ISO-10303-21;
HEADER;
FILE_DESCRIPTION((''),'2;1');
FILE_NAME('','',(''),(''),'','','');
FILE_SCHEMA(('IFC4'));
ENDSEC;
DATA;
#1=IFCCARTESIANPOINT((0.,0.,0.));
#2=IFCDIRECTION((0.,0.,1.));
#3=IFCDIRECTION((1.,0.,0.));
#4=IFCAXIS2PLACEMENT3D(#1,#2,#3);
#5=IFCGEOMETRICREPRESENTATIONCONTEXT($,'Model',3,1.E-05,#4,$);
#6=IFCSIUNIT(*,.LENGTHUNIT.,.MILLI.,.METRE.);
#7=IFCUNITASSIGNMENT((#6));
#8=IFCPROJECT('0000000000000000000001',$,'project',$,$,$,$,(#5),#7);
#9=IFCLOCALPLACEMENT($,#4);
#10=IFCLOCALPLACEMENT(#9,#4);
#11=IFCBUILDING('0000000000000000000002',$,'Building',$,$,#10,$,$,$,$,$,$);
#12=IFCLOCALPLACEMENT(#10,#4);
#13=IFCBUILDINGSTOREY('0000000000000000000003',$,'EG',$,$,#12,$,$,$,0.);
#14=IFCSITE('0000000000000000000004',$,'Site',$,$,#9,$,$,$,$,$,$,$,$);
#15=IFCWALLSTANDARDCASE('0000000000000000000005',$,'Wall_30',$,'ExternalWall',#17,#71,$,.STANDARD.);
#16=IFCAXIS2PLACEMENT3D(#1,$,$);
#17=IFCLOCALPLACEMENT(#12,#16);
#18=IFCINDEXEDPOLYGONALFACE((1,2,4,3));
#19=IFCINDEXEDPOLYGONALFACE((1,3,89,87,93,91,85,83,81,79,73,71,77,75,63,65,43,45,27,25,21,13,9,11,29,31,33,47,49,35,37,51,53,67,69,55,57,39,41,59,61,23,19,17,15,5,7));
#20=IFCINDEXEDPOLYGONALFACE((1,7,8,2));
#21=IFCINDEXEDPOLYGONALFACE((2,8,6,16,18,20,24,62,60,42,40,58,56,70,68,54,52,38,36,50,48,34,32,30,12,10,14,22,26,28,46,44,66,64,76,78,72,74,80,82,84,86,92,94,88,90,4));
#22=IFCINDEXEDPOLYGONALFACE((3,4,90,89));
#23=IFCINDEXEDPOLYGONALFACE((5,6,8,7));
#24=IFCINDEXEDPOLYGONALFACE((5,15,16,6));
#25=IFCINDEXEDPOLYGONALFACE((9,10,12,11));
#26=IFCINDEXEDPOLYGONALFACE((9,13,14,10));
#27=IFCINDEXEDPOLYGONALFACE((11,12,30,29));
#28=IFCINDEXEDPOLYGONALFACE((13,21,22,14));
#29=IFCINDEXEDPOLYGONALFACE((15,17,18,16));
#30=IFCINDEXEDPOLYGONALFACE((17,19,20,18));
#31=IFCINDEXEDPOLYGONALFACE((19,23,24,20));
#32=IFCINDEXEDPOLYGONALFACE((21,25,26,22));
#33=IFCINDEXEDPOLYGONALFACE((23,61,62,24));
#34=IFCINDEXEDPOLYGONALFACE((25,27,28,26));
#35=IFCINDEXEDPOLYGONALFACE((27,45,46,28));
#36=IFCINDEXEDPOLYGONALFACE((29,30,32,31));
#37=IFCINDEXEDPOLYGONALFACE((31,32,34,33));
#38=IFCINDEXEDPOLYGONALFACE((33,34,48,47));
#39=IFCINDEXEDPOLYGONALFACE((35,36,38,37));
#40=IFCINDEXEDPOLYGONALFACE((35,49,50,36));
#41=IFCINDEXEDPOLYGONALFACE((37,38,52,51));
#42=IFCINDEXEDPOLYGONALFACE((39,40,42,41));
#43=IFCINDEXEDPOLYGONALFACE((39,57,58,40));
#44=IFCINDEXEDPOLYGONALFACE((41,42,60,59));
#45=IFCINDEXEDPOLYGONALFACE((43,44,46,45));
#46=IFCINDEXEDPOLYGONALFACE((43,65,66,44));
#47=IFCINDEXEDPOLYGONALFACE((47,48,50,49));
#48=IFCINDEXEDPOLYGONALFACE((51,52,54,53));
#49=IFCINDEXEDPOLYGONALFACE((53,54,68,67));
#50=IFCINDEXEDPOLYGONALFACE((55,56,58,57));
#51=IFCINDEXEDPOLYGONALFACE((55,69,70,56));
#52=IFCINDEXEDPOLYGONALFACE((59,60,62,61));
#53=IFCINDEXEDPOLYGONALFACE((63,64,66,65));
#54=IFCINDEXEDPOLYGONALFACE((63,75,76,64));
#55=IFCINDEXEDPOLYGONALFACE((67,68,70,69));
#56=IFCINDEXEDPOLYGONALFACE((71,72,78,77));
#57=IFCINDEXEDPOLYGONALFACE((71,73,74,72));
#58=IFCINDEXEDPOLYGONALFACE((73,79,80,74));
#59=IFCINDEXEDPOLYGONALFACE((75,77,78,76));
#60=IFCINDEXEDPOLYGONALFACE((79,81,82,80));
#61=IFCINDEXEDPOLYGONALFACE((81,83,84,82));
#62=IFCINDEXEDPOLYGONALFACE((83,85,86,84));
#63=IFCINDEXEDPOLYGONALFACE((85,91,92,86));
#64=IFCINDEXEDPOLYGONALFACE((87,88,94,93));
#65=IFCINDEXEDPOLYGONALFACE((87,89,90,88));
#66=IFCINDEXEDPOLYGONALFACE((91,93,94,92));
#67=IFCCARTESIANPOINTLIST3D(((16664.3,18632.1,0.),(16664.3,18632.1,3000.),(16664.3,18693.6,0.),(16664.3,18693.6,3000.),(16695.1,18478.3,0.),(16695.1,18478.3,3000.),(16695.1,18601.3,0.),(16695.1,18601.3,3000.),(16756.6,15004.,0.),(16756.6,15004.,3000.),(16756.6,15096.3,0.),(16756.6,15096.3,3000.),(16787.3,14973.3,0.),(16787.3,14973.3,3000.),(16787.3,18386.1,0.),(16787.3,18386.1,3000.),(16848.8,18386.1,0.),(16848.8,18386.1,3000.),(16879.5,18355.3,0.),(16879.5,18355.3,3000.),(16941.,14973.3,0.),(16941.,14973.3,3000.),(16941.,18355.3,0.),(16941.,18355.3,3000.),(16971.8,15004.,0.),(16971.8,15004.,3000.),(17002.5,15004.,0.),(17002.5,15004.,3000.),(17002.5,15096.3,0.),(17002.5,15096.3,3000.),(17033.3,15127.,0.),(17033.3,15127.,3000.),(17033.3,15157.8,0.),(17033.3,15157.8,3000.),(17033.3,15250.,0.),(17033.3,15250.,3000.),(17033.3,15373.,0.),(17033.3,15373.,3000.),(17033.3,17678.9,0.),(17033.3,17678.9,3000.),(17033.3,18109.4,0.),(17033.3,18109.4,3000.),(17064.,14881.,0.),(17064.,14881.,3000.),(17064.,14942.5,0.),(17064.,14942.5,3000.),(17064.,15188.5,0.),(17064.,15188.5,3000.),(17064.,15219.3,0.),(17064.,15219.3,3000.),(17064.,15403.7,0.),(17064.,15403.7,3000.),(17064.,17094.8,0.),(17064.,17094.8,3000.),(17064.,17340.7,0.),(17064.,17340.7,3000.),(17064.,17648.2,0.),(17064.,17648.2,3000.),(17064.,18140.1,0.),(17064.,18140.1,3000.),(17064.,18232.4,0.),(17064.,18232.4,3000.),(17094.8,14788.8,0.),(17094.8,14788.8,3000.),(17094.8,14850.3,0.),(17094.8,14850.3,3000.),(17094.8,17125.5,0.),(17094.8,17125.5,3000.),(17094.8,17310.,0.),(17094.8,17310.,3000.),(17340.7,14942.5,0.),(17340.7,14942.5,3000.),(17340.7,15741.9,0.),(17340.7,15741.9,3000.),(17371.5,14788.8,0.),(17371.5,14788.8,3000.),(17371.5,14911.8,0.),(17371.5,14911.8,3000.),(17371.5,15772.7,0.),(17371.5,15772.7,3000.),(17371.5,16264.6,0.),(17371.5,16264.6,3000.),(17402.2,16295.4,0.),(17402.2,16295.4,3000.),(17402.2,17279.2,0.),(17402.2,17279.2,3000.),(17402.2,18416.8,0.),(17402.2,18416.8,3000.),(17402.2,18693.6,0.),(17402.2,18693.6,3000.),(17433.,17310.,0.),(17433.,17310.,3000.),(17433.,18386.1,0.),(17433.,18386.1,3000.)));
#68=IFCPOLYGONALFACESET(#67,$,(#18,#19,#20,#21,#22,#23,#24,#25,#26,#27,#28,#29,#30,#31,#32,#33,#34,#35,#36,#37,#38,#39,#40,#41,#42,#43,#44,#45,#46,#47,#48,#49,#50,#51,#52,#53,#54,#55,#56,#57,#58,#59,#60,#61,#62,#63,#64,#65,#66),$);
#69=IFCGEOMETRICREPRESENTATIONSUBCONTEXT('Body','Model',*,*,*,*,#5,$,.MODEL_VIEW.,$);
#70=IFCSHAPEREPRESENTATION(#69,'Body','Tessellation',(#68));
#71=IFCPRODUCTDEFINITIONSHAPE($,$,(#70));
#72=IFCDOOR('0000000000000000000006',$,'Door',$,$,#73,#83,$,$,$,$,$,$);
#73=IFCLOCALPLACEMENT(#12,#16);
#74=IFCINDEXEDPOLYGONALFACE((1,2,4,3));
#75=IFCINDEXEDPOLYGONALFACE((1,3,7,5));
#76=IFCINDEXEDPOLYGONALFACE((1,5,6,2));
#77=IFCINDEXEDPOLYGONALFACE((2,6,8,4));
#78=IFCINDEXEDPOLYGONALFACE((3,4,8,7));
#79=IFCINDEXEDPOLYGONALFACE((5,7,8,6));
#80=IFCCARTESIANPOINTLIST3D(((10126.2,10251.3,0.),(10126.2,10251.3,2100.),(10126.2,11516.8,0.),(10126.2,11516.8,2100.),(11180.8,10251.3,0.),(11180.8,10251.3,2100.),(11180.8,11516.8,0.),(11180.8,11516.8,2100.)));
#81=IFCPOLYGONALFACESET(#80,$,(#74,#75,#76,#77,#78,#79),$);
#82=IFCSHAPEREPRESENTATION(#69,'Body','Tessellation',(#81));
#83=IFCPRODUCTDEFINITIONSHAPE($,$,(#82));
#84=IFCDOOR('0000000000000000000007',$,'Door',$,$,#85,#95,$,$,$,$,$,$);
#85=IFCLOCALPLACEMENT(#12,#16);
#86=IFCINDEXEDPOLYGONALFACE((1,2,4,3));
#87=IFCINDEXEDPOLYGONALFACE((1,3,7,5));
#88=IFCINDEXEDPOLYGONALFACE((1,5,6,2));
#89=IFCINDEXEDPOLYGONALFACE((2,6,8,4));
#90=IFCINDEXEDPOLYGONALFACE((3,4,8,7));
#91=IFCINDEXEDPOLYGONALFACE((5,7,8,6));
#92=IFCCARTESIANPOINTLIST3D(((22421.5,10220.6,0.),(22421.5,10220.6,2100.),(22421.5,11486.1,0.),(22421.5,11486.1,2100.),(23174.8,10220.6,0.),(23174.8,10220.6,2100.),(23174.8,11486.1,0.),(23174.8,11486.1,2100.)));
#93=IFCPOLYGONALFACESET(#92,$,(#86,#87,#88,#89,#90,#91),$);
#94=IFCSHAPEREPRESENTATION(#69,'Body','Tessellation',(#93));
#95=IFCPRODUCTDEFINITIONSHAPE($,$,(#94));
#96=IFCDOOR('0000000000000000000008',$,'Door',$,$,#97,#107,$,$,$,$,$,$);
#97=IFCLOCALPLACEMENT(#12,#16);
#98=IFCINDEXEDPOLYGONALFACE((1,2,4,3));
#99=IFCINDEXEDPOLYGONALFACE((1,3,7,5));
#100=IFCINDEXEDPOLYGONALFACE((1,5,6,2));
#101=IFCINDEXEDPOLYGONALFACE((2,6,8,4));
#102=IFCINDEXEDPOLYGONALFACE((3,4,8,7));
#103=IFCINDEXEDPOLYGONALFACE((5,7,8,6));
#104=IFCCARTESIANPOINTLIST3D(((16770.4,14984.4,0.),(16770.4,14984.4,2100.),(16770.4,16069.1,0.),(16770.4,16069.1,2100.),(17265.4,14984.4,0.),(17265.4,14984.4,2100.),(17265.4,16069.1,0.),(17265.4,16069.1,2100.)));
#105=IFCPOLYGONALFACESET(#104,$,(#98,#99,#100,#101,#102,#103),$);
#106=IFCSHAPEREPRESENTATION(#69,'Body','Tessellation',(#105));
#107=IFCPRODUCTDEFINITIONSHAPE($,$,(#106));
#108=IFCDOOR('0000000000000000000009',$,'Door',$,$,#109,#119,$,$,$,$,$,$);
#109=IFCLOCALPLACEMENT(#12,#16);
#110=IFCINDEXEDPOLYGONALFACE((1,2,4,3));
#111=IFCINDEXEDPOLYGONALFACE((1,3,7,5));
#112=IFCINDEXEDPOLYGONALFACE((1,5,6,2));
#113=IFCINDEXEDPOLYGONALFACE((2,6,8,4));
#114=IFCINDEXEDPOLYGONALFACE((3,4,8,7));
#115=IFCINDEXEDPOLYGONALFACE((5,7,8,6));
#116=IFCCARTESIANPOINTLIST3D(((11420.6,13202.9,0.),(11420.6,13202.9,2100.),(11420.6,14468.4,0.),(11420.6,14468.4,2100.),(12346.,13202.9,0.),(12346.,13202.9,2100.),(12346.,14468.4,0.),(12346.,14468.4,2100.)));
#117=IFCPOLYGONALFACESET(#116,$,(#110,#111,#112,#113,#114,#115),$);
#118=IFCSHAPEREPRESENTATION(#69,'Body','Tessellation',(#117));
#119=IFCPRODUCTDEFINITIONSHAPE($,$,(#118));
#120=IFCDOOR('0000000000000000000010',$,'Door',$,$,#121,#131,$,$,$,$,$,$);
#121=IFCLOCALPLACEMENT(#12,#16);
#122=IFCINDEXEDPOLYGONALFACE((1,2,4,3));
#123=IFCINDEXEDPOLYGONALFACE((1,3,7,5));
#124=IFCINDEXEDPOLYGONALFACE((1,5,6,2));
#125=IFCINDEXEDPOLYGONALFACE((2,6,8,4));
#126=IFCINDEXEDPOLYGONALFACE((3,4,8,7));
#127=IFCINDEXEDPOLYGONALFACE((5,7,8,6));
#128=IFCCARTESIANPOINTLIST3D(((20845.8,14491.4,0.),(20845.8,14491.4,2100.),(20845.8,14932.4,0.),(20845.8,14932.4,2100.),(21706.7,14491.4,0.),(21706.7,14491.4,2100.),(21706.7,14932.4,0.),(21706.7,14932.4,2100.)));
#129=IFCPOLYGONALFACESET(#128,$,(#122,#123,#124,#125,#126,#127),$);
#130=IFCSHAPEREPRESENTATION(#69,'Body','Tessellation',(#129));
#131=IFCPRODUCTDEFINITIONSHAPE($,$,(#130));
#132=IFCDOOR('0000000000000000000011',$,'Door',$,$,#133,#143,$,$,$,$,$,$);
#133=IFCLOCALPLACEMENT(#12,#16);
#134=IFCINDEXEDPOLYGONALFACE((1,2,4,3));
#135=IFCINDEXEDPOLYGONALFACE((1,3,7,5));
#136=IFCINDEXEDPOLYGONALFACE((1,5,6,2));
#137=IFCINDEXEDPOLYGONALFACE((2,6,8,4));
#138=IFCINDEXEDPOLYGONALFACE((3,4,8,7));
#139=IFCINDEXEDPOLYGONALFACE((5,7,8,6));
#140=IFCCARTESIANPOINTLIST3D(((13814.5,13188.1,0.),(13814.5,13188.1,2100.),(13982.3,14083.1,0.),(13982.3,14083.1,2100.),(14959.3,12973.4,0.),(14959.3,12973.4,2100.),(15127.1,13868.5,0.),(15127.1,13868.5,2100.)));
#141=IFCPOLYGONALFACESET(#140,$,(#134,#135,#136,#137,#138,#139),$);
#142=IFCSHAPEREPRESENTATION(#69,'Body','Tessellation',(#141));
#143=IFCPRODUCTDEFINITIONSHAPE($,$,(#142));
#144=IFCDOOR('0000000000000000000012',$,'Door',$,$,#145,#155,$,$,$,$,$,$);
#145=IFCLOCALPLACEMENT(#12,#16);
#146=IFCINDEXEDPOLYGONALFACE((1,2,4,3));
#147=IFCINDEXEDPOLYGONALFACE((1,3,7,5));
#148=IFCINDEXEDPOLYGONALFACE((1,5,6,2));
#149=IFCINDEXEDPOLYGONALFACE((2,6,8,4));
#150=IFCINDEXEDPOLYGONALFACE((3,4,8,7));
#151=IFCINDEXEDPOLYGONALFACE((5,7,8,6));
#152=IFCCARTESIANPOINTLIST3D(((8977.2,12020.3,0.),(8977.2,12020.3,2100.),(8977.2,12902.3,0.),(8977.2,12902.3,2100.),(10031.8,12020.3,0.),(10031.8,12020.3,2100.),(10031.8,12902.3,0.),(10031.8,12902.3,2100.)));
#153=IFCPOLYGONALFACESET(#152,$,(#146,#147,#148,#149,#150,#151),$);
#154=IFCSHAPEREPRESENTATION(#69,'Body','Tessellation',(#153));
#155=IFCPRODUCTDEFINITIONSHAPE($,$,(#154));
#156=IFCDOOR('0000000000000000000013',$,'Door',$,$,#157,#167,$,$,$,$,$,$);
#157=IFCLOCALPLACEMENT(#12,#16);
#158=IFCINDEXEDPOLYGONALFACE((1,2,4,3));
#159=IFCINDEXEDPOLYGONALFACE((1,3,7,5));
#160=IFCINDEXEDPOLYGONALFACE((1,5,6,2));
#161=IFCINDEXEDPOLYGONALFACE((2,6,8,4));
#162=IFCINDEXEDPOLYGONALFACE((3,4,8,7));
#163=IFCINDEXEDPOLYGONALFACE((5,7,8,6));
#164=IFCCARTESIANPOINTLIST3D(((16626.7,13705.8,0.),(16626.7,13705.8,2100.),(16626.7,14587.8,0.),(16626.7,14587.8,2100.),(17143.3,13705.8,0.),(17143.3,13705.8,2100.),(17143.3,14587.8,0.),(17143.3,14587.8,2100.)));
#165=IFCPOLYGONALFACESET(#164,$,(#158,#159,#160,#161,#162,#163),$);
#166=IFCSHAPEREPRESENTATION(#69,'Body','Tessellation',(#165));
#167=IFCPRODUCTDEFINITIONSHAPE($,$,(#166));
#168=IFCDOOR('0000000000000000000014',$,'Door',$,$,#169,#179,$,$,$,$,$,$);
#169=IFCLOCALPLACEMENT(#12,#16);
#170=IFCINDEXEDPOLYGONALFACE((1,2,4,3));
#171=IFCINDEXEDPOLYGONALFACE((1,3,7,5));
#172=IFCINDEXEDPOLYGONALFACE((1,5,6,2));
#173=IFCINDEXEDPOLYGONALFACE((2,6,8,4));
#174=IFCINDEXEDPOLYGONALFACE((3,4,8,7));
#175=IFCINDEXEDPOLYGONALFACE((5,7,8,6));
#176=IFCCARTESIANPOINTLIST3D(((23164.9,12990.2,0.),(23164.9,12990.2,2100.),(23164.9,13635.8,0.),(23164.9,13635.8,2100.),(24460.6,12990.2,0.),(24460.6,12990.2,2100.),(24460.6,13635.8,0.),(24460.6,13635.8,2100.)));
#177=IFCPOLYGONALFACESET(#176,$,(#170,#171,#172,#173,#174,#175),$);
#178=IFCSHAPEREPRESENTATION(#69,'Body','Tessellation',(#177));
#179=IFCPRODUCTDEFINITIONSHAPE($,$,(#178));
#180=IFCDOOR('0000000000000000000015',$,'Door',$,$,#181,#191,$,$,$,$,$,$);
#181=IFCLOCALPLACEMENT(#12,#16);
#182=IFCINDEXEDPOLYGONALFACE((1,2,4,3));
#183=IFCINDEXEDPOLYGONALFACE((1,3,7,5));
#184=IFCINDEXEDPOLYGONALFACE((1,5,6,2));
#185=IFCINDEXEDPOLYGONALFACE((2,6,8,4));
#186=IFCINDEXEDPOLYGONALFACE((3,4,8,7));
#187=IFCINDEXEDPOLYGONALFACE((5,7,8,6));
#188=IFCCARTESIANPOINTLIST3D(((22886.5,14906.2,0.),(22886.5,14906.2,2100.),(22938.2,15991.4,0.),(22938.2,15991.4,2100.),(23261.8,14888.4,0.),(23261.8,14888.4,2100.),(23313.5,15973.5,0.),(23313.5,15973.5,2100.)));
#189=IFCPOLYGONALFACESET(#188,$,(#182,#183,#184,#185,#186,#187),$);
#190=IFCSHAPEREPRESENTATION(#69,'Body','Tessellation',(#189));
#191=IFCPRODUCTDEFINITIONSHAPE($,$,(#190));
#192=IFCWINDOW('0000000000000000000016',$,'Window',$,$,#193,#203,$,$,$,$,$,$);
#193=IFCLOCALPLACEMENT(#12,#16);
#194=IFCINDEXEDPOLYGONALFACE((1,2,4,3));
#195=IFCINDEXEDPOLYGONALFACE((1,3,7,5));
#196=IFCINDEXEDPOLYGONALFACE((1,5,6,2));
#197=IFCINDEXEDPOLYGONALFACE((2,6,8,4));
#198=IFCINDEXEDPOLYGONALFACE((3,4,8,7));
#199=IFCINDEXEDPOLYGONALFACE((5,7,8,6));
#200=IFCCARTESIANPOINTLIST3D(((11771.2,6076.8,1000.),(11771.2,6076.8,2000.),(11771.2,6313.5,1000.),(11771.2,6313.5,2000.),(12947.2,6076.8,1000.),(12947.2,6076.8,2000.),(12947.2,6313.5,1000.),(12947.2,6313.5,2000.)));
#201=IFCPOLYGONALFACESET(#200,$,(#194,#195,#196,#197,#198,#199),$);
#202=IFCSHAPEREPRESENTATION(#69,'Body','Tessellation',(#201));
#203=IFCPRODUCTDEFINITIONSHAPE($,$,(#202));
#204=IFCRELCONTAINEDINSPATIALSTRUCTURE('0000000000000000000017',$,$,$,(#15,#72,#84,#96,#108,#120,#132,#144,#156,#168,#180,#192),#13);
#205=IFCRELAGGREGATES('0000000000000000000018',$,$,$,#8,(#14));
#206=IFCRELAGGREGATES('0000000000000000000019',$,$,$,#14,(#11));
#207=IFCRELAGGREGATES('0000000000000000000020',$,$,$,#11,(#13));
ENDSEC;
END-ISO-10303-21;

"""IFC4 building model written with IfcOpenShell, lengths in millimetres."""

from ifc_helpers import new_model, si_unit, frame, origin_with_axes, place, context, subcontext, project, spatial, polyline, rectangle, outline, extrude, element, save


model = new_model("IFC4")

# Units and contexts
model_context = context("Model", 3, precision=1e-05, world=origin_with_axes())
body_context = subcontext(model_context, "Body", "Model", "MODEL_VIEW")
ifc_project = project(units=[si_unit("LENGTHUNIT", "METRE", prefix="MILLI")], contexts=[model_context])

# Site, building, storey
site_placement = place(None, origin_with_axes())
site = spatial("IfcSite", under=ifc_project, at=site_placement, Name="Site")
building_placement = place(site_placement, origin_with_axes())
building = spatial("IfcBuilding", under=site, at=building_placement, Name="Building")
storey_placement = place(building_placement, origin_with_axes())
storey = spatial("IfcBuildingStorey", under=building, at=storey_placement, Name="EG", Elevation=0.0)

# Wall
wall_placement = place(storey_placement, origin_with_axes())
element("IfcWallStandardCase", 1, at=wall_placement, inside=storey, Name="Wall_30", ObjectType="ExternalWall", PredefinedType="STANDARD", context=body_context, shape_type="SweptSolid", body=[
    extrude(outline(polyline([(17094.8, 14788.8, 0.0), (17094.8, 14850.3, 0.0), (17064.0, 14881.0, 0.0), (17064.0, 14942.5, 0.0), (17002.5, 15004.0, 0.0), (16971.8, 15004.0, 0.0), (16941.0, 14973.3, 0.0), (16787.3, 14973.3, 0.0), (16756.6, 15004.0, 0.0), (16756.6, 15096.3, 0.0), (17002.5, 15096.3, 0.0), (17033.3, 15127.0, 0.0), (17033.3, 15157.8, 0.0), (17064.0, 15188.5, 0.0), (17064.0, 15219.3, 0.0), (17033.3, 15250.0, 0.0), (17033.3, 15373.0, 0.0), (17064.0, 15403.7, 0.0), (17064.0, 17094.8, 0.0), (17094.8, 17125.5, 0.0), (17094.8, 17310.0, 0.0), (17064.0, 17340.7, 0.0), (17064.0, 17648.2, 0.0), (17033.3, 17678.9, 0.0), (17033.3, 18109.4, 0.0), (17064.0, 18140.1, 0.0), (17064.0, 18232.4, 0.0), (16941.0, 18355.3, 0.0), (16879.5, 18355.3, 0.0), (16848.8, 18386.1, 0.0), (16787.3, 18386.1, 0.0), (16695.1, 18478.3, 0.0), (16695.1, 18601.3, 0.0), (16664.3, 18632.1, 0.0), (16664.3, 18693.6, 0.0), (17402.2, 18693.6, 0.0), (17402.2, 18416.8, 0.0), (17433.0, 18386.1, 0.0), (17433.0, 17310.0, 0.0), (17402.2, 17279.2, 0.0), (17402.2, 16295.4, 0.0), (17371.5, 16264.6, 0.0), (17371.5, 15772.7, 0.0), (17340.7, 15741.9, 0.0), (17340.7, 14942.5, 0.0), (17371.5, 14911.8, 0.0), (17371.5, 14788.8, 0.0), (17094.8, 14788.8, 0.0)])), origin_with_axes(), (0.0, 0.0, 1.0), 3000.0),
])

# Doors
door_1_placement = place(storey_placement, origin_with_axes())
element("IfcDoor", 2, at=door_1_placement, inside=storey, Name="Door", context=body_context, shape_type="SweptSolid", body=[
    extrude(rectangle(XDim=1265.5, YDim=1054.6), frame((10653.5, 10884.1, 0.0), z_axis=(0.0, 0.0, 1.0), x_axis=(0.0, -1.0, 0.0)), (0.0, 0.0, 1.0), 2100.0),
])
door_2_placement = place(storey_placement, origin_with_axes())
element("IfcDoor", 3, at=door_2_placement, inside=storey, Name="Door", context=body_context, shape_type="SweptSolid", body=[
    extrude(rectangle(XDim=1265.5, YDim=753.3), frame((22798.1, 10853.3, 0.0), z_axis=(0.0, 0.0, 1.0), x_axis=(0.0, 1.0, 0.0)), (0.0, 0.0, 1.0), 2100.0),
])
door_3_placement = place(storey_placement, origin_with_axes())
element("IfcDoor", 4, at=door_3_placement, inside=storey, Name="Door", context=body_context, shape_type="SweptSolid", body=[
    extrude(rectangle(XDim=1084.7, YDim=495.0), frame((17017.9, 15526.7, 0.0), z_axis=(0.0, 0.0, 1.0), x_axis=(0.0, 1.0, 0.0)), (0.0, 0.0, 1.0), 2100.0),
])
door_4_placement = place(storey_placement, origin_with_axes())
element("IfcDoor", 5, at=door_4_placement, inside=storey, Name="Door", context=body_context, shape_type="SweptSolid", body=[
    extrude(rectangle(XDim=1265.5, YDim=925.5), frame((11883.3, 13835.7, 0.0), z_axis=(0.0, 0.0, 1.0), x_axis=(0.0, -1.0, 0.0)), (0.0, 0.0, 1.0), 2100.0),
])
door_5_placement = place(storey_placement, origin_with_axes())
element("IfcDoor", 6, at=door_5_placement, inside=storey, Name="Door", context=body_context, shape_type="SweptSolid", body=[
    extrude(rectangle(XDim=441.0, YDim=860.9), frame((21276.2, 14711.9, 0.0), z_axis=(0.0, 0.0, 1.0), x_axis=(0.0, -1.0, 0.0)), (0.0, 0.0, 1.0), 2100.0),
])
door_6_placement = place(storey_placement, origin_with_axes())
element("IfcDoor", 7, at=door_6_placement, inside=storey, Name="Door", context=body_context, shape_type="SweptSolid", body=[
    extrude(rectangle(XDim=910.7, YDim=1164.8), frame((14470.8, 13528.3, 0.0), z_axis=(0.0, 0.0, 1.0), x_axis=(-0.184288, -0.982872, 0.0)), (0.0, 0.0, 1.0), 2100.0),
])
door_7_placement = place(storey_placement, origin_with_axes())
element("IfcDoor", 8, at=door_7_placement, inside=storey, Name="Door", context=body_context, shape_type="SweptSolid", body=[
    extrude(rectangle(XDim=882.0, YDim=1054.6), frame((9504.5, 12461.3, 0.0), z_axis=(0.0, 0.0, 1.0), x_axis=(0.0, -1.0, 0.0)), (0.0, 0.0, 1.0), 2100.0),
])
door_8_placement = place(storey_placement, origin_with_axes())
element("IfcDoor", 9, at=door_8_placement, inside=storey, Name="Door", context=body_context, shape_type="SweptSolid", body=[
    extrude(rectangle(XDim=882.0, YDim=516.5), frame((16885.0, 14146.8, 0.0), z_axis=(0.0, 0.0, 1.0), x_axis=(0.0, -1.0, 0.0)), (0.0, 0.0, 1.0), 2100.0),
])
door_9_placement = place(storey_placement, origin_with_axes())
element("IfcDoor", 10, at=door_9_placement, inside=storey, Name="Door", context=body_context, shape_type="SweptSolid", body=[
    extrude(rectangle(XDim=1295.6, YDim=645.7), frame((23812.8, 13313.0, 0.0), z_axis=(0.0, 0.0, 1.0), x_axis=(1.0, 0.0, 0.0)), (0.0, 0.0, 1.0), 2100.0),
])
door_10_placement = place(storey_placement, origin_with_axes())
element("IfcDoor", 11, at=door_10_placement, inside=storey, Name="Door", context=body_context, shape_type="SweptSolid", body=[
    extrude(rectangle(XDim=1086.4, YDim=375.7), frame((23100.0, 15439.9, 0.0), z_axis=(0.0, 0.0, 1.0), x_axis=(-0.047565, -0.998868, 0.0)), (0.0, 0.0, 1.0), 2100.0),
])

# Window
window_1_placement = place(storey_placement, origin_with_axes())
element("IfcWindow", 12, at=window_1_placement, inside=storey, Name="Window", context=body_context, shape_type="SweptSolid", body=[
    extrude(rectangle(XDim=1176.0, YDim=236.7), frame((12359.2, 6195.2, 1000.0), z_axis=(0.0, 0.0, 1.0), x_axis=(1.0, 0.0, 0.0)), (0.0, 0.0, 1.0), 1000.0),
])

save(model, "model.ifc")
